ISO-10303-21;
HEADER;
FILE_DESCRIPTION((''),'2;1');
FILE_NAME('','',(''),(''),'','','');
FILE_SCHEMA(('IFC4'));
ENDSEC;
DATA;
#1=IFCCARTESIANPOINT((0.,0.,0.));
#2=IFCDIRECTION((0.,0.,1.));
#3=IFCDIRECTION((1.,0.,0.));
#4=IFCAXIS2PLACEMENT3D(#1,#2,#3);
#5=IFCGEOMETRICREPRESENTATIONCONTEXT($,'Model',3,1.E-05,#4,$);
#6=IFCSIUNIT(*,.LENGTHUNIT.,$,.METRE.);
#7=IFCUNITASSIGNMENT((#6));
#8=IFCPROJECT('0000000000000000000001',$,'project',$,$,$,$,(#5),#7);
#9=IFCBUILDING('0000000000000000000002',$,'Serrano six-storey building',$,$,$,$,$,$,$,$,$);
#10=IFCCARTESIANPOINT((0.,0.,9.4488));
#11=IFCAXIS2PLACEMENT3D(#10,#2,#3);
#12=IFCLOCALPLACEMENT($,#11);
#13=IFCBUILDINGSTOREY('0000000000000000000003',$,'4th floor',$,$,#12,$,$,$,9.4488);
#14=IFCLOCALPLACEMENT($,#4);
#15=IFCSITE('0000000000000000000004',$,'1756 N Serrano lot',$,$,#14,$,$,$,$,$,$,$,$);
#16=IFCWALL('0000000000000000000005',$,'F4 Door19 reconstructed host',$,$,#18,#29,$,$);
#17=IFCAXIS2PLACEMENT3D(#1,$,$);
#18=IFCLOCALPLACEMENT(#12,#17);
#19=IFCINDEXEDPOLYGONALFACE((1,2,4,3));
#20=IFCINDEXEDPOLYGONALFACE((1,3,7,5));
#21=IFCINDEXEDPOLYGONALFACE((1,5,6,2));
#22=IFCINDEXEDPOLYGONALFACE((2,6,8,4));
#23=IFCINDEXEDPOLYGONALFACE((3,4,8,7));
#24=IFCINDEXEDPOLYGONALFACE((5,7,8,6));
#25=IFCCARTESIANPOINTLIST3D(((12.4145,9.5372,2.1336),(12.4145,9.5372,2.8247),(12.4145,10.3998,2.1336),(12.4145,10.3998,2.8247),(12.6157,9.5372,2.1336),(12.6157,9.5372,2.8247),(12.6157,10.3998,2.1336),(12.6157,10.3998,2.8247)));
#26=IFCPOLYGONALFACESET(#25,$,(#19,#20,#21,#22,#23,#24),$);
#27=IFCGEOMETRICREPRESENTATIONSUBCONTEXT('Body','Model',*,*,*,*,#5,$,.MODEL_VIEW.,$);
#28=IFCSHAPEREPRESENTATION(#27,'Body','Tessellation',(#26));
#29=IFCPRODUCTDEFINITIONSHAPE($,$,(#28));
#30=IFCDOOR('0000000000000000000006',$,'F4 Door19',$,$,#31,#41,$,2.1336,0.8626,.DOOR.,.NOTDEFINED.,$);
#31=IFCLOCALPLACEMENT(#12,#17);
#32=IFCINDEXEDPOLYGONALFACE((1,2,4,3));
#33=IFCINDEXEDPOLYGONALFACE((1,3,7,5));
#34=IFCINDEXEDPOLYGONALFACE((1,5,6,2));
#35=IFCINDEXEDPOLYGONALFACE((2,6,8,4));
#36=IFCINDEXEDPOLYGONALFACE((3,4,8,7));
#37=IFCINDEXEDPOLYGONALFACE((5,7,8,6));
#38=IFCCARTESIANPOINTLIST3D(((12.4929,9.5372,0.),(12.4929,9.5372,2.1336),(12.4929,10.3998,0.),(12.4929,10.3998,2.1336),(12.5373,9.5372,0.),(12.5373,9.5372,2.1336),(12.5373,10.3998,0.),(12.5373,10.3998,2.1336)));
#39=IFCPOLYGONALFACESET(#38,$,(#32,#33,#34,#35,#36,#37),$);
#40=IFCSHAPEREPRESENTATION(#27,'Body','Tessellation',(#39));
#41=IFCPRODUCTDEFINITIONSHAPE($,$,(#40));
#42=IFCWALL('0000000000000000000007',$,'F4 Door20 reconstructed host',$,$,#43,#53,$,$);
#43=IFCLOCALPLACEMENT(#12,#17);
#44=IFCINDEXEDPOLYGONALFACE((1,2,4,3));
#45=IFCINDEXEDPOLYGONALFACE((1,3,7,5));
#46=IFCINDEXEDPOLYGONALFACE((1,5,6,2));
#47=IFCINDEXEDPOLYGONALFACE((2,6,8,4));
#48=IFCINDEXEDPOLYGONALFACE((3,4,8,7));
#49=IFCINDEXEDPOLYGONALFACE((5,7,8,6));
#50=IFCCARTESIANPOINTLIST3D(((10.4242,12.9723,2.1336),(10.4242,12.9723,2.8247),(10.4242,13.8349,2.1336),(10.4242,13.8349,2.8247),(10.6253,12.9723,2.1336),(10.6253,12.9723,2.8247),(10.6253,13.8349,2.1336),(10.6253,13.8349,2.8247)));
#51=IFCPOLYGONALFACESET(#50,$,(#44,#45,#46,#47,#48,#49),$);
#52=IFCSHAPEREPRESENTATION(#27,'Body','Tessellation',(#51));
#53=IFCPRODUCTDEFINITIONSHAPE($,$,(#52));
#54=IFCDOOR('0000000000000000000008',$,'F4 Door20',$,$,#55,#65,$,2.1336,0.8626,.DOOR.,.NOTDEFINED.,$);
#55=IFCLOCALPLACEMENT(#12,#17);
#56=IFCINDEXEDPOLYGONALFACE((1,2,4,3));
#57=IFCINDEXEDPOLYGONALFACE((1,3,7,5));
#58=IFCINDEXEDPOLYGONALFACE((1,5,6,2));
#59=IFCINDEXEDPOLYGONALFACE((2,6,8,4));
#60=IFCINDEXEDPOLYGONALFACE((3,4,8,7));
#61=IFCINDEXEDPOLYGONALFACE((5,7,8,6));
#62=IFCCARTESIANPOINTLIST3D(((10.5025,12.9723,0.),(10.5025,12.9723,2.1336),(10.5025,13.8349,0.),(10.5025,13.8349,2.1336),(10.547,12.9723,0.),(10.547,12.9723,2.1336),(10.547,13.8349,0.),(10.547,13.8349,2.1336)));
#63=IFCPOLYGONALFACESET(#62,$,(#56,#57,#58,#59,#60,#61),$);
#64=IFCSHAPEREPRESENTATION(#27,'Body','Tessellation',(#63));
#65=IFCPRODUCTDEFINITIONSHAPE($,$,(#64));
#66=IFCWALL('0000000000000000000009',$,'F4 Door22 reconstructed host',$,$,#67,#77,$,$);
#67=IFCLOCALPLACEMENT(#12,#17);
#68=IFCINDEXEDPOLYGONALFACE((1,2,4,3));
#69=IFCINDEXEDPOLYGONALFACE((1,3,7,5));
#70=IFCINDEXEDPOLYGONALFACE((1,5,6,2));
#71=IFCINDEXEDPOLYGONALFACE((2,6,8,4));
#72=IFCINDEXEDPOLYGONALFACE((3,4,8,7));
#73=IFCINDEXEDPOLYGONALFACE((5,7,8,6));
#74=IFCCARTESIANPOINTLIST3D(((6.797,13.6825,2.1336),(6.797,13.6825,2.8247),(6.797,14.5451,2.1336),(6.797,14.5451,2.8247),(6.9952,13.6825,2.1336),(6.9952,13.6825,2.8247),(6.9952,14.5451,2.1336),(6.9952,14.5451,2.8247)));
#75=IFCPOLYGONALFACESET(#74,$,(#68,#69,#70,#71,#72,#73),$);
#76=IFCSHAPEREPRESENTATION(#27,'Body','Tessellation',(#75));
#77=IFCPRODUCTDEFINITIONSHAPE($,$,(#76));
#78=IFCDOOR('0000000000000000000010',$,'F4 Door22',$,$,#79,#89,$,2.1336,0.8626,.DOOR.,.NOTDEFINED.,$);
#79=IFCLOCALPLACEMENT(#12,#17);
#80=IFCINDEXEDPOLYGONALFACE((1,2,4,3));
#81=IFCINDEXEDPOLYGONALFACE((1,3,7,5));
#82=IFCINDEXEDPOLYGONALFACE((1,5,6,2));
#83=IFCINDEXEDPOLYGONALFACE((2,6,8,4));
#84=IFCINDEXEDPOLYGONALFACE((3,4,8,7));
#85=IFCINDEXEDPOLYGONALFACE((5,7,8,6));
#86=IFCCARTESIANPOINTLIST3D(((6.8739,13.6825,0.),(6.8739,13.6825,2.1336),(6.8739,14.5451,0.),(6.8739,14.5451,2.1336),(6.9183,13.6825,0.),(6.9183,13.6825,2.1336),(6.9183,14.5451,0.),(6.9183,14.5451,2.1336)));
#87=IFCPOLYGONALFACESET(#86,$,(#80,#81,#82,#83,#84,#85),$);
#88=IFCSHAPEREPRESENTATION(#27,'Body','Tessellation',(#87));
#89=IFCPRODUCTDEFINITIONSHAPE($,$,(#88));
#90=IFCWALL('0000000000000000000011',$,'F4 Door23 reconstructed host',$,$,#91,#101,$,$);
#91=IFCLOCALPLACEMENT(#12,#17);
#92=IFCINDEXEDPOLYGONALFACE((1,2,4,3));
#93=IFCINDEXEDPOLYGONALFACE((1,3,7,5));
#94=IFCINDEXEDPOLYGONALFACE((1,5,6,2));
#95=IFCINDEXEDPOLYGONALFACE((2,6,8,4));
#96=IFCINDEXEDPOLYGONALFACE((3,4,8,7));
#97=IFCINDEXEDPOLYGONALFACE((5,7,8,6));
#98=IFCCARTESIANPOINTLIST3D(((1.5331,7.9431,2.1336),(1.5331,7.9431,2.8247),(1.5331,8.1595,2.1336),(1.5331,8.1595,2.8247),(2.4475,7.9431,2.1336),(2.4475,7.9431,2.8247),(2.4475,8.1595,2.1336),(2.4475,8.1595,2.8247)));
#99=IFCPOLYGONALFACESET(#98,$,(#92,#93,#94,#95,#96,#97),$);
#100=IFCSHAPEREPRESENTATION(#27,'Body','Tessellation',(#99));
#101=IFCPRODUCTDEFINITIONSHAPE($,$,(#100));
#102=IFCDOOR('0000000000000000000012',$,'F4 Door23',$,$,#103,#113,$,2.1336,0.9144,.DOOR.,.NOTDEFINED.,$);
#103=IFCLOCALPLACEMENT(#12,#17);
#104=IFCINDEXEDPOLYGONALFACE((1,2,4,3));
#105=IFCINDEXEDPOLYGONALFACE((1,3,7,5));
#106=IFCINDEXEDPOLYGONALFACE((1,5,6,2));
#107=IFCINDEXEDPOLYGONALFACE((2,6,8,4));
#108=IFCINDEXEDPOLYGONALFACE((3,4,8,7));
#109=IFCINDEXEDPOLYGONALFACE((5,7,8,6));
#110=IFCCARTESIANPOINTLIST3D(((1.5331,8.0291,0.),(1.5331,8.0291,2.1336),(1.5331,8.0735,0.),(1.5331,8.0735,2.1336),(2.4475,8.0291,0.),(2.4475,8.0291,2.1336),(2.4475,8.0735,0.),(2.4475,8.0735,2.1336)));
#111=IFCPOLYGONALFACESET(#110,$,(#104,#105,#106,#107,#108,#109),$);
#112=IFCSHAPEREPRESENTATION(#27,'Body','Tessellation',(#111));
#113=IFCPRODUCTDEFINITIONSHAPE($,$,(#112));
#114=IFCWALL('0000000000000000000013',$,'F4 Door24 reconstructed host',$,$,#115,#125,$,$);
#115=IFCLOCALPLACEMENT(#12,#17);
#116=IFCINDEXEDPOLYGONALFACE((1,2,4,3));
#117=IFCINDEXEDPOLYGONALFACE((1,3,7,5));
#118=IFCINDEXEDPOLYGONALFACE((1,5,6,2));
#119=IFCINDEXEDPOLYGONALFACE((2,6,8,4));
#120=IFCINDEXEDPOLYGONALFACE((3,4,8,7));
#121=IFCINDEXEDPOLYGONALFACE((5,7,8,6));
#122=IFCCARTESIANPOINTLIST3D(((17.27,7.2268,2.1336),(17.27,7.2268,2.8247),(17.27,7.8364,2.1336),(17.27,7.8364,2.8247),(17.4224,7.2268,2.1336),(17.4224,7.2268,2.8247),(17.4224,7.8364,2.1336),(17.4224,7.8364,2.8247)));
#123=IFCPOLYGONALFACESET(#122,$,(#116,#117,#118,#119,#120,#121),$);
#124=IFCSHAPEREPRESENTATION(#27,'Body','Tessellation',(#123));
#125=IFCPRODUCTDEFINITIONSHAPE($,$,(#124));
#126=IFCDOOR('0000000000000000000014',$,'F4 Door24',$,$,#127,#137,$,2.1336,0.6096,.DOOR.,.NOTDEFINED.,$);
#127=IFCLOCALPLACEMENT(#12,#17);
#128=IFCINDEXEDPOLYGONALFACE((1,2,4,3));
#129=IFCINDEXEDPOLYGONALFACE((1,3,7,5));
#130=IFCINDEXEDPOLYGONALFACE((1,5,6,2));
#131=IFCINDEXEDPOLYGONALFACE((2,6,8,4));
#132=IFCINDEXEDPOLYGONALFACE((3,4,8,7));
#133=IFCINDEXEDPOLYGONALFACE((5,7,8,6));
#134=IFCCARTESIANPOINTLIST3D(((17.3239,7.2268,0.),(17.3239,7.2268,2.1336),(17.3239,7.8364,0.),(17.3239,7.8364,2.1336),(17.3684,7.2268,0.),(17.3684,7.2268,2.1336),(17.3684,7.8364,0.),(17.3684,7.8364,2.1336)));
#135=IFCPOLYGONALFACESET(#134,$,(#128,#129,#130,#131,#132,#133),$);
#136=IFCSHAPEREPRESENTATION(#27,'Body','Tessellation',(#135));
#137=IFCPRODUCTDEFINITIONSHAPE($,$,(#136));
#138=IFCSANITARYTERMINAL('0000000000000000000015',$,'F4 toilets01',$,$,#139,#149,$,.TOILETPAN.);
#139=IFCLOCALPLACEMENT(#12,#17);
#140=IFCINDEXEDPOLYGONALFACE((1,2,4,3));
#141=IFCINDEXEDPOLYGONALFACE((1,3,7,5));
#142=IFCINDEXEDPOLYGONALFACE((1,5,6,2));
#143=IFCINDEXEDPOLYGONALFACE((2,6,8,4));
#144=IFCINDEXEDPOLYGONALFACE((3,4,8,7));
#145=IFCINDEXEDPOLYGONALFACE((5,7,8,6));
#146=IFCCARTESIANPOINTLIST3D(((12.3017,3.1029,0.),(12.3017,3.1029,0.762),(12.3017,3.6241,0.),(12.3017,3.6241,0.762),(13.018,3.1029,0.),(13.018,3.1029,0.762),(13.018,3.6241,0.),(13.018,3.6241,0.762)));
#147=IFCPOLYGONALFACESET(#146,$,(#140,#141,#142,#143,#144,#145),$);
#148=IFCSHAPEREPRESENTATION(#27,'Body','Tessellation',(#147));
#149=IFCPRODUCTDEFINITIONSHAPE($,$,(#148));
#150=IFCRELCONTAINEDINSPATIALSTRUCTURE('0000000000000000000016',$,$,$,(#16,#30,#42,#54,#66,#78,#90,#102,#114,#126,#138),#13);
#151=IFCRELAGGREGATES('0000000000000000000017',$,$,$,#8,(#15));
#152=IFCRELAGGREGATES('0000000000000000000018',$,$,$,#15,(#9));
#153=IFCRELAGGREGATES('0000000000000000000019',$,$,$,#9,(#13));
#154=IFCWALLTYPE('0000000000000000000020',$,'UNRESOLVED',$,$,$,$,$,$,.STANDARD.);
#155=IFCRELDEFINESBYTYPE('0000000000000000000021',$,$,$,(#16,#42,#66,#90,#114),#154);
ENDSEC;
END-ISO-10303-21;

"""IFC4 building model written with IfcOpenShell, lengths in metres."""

from ifc_helpers import new_model, si_unit, frame, origin_with_axes, place, context, subcontext, project, spatial, polyline, outline, extrude, type_object, element, fill, save


model = new_model("IFC4")

# Units and contexts
model_context = context("Model", 3, precision=1e-05, world=origin_with_axes())
body_context = subcontext(model_context, "Body", "Model", "MODEL_VIEW")
ifc_project = project(units=[si_unit("LENGTHUNIT", "METRE")], contexts=[model_context])

# Site, building, storey
site_placement = place(None, origin_with_axes())
site = spatial("IfcSite", under=ifc_project, at=site_placement, Name="1756 N Serrano lot")
building = spatial("IfcBuilding", under=site, Name="Serrano six-storey building")
storey_placement = place(None, frame((0.0, 0.0, 9.4488), z_axis=(0.0, 0.0, 1.0), x_axis=(1.0, 0.0, 0.0)))
storey = spatial("IfcBuildingStorey", under=building, at=storey_placement, Name="4th floor", Elevation=9.4488)

# Walls, openings, doors
wall_type_1 = type_object("IfcWallType", Name="UNRESOLVED", PredefinedType="STANDARD")
wall_1_placement = place(storey_placement, frame((0.0, 0.0, -9.4488), z_axis=(0.0, 0.0, 1.0), x_axis=(1.0, 0.0, 0.0)))
wall_1 = element("IfcWall", 1, at=wall_1_placement, inside=storey, type_object=wall_type_1, Name="F4 Door19 reconstructed host", context=body_context, shape_type="SweptSolid", body=[
    extrude(outline(polyline([(12.4145, 10.3998), (12.6157, 10.3998), (12.6157, 9.5372), (12.4145, 9.5372), (12.4145, 10.3998)])), frame((0.0, 0.0, 9.4488)), (0.0, 0.0, 1.0), 2.8247),
])
opening_1_placement = place(None, origin_with_axes())
opening_1 = element("IfcOpeningElement", 2, at=opening_1_placement, cuts=wall_1, PredefinedType="OPENING", context=body_context, shape_type="SweptSolid", body=[
    extrude(outline(polyline([(12.3962, 10.3998), (12.634, 10.3998), (12.634, 9.5372), (12.3962, 9.5372), (12.3962, 10.3998)])), frame((0.0, 0.0, 9.4488)), (0.0, 0.0, 1.0), 2.1336),
])
door_1_placement = place(storey_placement, frame((0.0, 0.0, -9.4488), z_axis=(0.0, 0.0, 1.0), x_axis=(1.0, 0.0, 0.0)))
door_1 = element("IfcDoor", 3, at=door_1_placement, inside=storey, Name="F4 Door19", OperationType="NOTDEFINED", OverallHeight=2.1336, OverallWidth=0.8626, PredefinedType="DOOR", context=body_context, shape_type="SweptSolid", body=[
    extrude(outline(polyline([(12.4929, 10.3998), (12.5373, 10.3998), (12.5373, 9.5372), (12.4929, 9.5372), (12.4929, 10.3998)])), frame((0.0, 0.0, 9.4488)), (0.0, 0.0, 1.0), 2.1336),
])
fill(opening_1, door_1)
wall_2_placement = place(storey_placement, frame((0.0, 0.0, -9.4488), z_axis=(0.0, 0.0, 1.0), x_axis=(1.0, 0.0, 0.0)))
wall_2 = element("IfcWall", 4, at=wall_2_placement, inside=storey, type_object=wall_type_1, Name="F4 Door20 reconstructed host", context=body_context, shape_type="SweptSolid", body=[
    extrude(outline(polyline([(10.6253, 12.9723), (10.4242, 12.9723), (10.4242, 13.8349), (10.6253, 13.8349), (10.6253, 12.9723)])), frame((0.0, 0.0, 9.4488)), (0.0, 0.0, 1.0), 2.8247),
])
opening_2_placement = place(None, origin_with_axes())
opening_2 = element("IfcOpeningElement", 5, at=opening_2_placement, cuts=wall_2, PredefinedType="OPENING", context=body_context, shape_type="SweptSolid", body=[
    extrude(outline(polyline([(10.6436, 12.9723), (10.4059, 12.9723), (10.4059, 13.8349), (10.6436, 13.8349), (10.6436, 12.9723)])), frame((0.0, 0.0, 9.4488)), (0.0, 0.0, 1.0), 2.1336),
])
door_2_placement = place(storey_placement, frame((0.0, 0.0, -9.4488), z_axis=(0.0, 0.0, 1.0), x_axis=(1.0, 0.0, 0.0)))
door_2 = element("IfcDoor", 6, at=door_2_placement, inside=storey, Name="F4 Door20", OperationType="NOTDEFINED", OverallHeight=2.1336, OverallWidth=0.8626, PredefinedType="DOOR", context=body_context, shape_type="SweptSolid", body=[
    extrude(outline(polyline([(10.547, 12.9723), (10.5025, 12.9723), (10.5025, 13.8349), (10.547, 13.8349), (10.547, 12.9723)])), frame((0.0, 0.0, 9.4488)), (0.0, 0.0, 1.0), 2.1336),
])
fill(opening_2, door_2)
wall_3_placement = place(storey_placement, frame((0.0, 0.0, -9.4488), z_axis=(0.0, 0.0, 1.0), x_axis=(1.0, 0.0, 0.0)))
wall_3 = element("IfcWall", 7, at=wall_3_placement, inside=storey, type_object=wall_type_1, Name="F4 Door22 reconstructed host", context=body_context, shape_type="SweptSolid", body=[
    extrude(outline(polyline([(6.9952, 13.6825), (6.797, 13.6825), (6.797, 14.5451), (6.9952, 14.5451), (6.9952, 13.6825)])), frame((0.0, 0.0, 9.4488)), (0.0, 0.0, 1.0), 2.8247),
])
opening_3_placement = place(None, origin_with_axes())
opening_3 = element("IfcOpeningElement", 8, at=opening_3_placement, cuts=wall_3, PredefinedType="OPENING", context=body_context, shape_type="SweptSolid", body=[
    extrude(outline(polyline([(7.0134, 13.6825), (6.7788, 13.6825), (6.7788, 14.5451), (7.0134, 14.5451), (7.0134, 13.6825)])), frame((0.0, 0.0, 9.4488)), (0.0, 0.0, 1.0), 2.1336),
])
door_3_placement = place(storey_placement, frame((0.0, 0.0, -9.4488), z_axis=(0.0, 0.0, 1.0), x_axis=(1.0, 0.0, 0.0)))
door_3 = element("IfcDoor", 9, at=door_3_placement, inside=storey, Name="F4 Door22", OperationType="NOTDEFINED", OverallHeight=2.1336, OverallWidth=0.8626, PredefinedType="DOOR", context=body_context, shape_type="SweptSolid", body=[
    extrude(outline(polyline([(6.9183, 13.6825), (6.8739, 13.6825), (6.8739, 14.5451), (6.9183, 14.5451), (6.9183, 13.6825)])), frame((0.0, 0.0, 9.4488)), (0.0, 0.0, 1.0), 2.1336),
])
fill(opening_3, door_3)
wall_4_placement = place(storey_placement, frame((0.0, 0.0, -9.4488), z_axis=(0.0, 0.0, 1.0), x_axis=(1.0, 0.0, 0.0)))
wall_4 = element("IfcWall", 10, at=wall_4_placement, inside=storey, type_object=wall_type_1, Name="F4 Door23 reconstructed host", context=body_context, shape_type="SweptSolid", body=[
    extrude(outline(polyline([(2.4475, 8.1595), (2.4475, 7.9431), (1.5331, 7.9431), (1.5331, 8.1595), (2.4475, 8.1595)])), frame((0.0, 0.0, 9.4488)), (0.0, 0.0, 1.0), 2.8247),
])
opening_4_placement = place(None, origin_with_axes())
opening_4 = element("IfcOpeningElement", 11, at=opening_4_placement, cuts=wall_4, PredefinedType="OPENING", context=body_context, shape_type="SweptSolid", body=[
    extrude(outline(polyline([(2.4475, 8.1778), (2.4475, 7.9248), (1.5331, 7.9248), (1.5331, 8.1778), (2.4475, 8.1778)])), frame((0.0, 0.0, 9.4488)), (0.0, 0.0, 1.0), 2.1336),
])
door_4_placement = place(storey_placement, frame((0.0, 0.0, -9.4488), z_axis=(0.0, 0.0, 1.0), x_axis=(1.0, 0.0, 0.0)))
door_4 = element("IfcDoor", 12, at=door_4_placement, inside=storey, Name="F4 Door23", OperationType="NOTDEFINED", OverallHeight=2.1336, OverallWidth=0.9144, PredefinedType="DOOR", context=body_context, shape_type="SweptSolid", body=[
    extrude(outline(polyline([(2.4475, 8.0735), (2.4475, 8.0291), (1.5331, 8.0291), (1.5331, 8.0735), (2.4475, 8.0735)])), frame((0.0, 0.0, 9.4488)), (0.0, 0.0, 1.0), 2.1336),
])
fill(opening_4, door_4)
wall_5_placement = place(storey_placement, frame((0.0, 0.0, -9.4488), z_axis=(0.0, 0.0, 1.0), x_axis=(1.0, 0.0, 0.0)))
wall_5 = element("IfcWall", 13, at=wall_5_placement, inside=storey, type_object=wall_type_1, Name="F4 Door24 reconstructed host", context=body_context, shape_type="SweptSolid", body=[
    extrude(outline(polyline([(17.27, 7.8364), (17.4224, 7.8364), (17.4224, 7.2268), (17.27, 7.2268), (17.27, 7.8364)])), frame((0.0, 0.0, 9.4488)), (0.0, 0.0, 1.0), 2.8247),
])
opening_5_placement = place(None, origin_with_axes())
opening_5 = element("IfcOpeningElement", 14, at=opening_5_placement, cuts=wall_5, PredefinedType="OPENING", context=body_context, shape_type="SweptSolid", body=[
    extrude(outline(polyline([(17.2517, 7.8364), (17.4407, 7.8364), (17.4407, 7.2268), (17.2517, 7.2268), (17.2517, 7.8364)])), frame((0.0, 0.0, 9.4488)), (0.0, 0.0, 1.0), 2.1336),
])
door_5_placement = place(storey_placement, frame((0.0, 0.0, -9.4488), z_axis=(0.0, 0.0, 1.0), x_axis=(1.0, 0.0, 0.0)))
door_5 = element("IfcDoor", 15, at=door_5_placement, inside=storey, Name="F4 Door24", OperationType="NOTDEFINED", OverallHeight=2.1336, OverallWidth=0.6096, PredefinedType="DOOR", context=body_context, shape_type="SweptSolid", body=[
    extrude(outline(polyline([(17.3239, 7.8364), (17.3684, 7.8364), (17.3684, 7.2268), (17.3239, 7.2268), (17.3239, 7.8364)])), frame((0.0, 0.0, 9.4488)), (0.0, 0.0, 1.0), 2.1336),
])
fill(opening_5, door_5)

# Sanitary terminal
sanitary_terminal_placement = place(storey_placement, frame((0.0, 0.0, -9.4488), z_axis=(0.0, 0.0, 1.0), x_axis=(1.0, 0.0, 0.0)))
element("IfcSanitaryTerminal", 16, at=sanitary_terminal_placement, inside=storey, Name="F4 toilets01", PredefinedType="TOILETPAN", context=body_context, shape_type="SweptSolid", body=[
    extrude(outline(polyline([(13.018, 3.1029), (13.018, 3.6241), (12.3017, 3.6241), (12.3017, 3.1029), (13.018, 3.1029)])), frame((0.0, 0.0, 9.4488)), (0.0, 0.0, 1.0), 0.762),
])

save(model, "model.ifc")
